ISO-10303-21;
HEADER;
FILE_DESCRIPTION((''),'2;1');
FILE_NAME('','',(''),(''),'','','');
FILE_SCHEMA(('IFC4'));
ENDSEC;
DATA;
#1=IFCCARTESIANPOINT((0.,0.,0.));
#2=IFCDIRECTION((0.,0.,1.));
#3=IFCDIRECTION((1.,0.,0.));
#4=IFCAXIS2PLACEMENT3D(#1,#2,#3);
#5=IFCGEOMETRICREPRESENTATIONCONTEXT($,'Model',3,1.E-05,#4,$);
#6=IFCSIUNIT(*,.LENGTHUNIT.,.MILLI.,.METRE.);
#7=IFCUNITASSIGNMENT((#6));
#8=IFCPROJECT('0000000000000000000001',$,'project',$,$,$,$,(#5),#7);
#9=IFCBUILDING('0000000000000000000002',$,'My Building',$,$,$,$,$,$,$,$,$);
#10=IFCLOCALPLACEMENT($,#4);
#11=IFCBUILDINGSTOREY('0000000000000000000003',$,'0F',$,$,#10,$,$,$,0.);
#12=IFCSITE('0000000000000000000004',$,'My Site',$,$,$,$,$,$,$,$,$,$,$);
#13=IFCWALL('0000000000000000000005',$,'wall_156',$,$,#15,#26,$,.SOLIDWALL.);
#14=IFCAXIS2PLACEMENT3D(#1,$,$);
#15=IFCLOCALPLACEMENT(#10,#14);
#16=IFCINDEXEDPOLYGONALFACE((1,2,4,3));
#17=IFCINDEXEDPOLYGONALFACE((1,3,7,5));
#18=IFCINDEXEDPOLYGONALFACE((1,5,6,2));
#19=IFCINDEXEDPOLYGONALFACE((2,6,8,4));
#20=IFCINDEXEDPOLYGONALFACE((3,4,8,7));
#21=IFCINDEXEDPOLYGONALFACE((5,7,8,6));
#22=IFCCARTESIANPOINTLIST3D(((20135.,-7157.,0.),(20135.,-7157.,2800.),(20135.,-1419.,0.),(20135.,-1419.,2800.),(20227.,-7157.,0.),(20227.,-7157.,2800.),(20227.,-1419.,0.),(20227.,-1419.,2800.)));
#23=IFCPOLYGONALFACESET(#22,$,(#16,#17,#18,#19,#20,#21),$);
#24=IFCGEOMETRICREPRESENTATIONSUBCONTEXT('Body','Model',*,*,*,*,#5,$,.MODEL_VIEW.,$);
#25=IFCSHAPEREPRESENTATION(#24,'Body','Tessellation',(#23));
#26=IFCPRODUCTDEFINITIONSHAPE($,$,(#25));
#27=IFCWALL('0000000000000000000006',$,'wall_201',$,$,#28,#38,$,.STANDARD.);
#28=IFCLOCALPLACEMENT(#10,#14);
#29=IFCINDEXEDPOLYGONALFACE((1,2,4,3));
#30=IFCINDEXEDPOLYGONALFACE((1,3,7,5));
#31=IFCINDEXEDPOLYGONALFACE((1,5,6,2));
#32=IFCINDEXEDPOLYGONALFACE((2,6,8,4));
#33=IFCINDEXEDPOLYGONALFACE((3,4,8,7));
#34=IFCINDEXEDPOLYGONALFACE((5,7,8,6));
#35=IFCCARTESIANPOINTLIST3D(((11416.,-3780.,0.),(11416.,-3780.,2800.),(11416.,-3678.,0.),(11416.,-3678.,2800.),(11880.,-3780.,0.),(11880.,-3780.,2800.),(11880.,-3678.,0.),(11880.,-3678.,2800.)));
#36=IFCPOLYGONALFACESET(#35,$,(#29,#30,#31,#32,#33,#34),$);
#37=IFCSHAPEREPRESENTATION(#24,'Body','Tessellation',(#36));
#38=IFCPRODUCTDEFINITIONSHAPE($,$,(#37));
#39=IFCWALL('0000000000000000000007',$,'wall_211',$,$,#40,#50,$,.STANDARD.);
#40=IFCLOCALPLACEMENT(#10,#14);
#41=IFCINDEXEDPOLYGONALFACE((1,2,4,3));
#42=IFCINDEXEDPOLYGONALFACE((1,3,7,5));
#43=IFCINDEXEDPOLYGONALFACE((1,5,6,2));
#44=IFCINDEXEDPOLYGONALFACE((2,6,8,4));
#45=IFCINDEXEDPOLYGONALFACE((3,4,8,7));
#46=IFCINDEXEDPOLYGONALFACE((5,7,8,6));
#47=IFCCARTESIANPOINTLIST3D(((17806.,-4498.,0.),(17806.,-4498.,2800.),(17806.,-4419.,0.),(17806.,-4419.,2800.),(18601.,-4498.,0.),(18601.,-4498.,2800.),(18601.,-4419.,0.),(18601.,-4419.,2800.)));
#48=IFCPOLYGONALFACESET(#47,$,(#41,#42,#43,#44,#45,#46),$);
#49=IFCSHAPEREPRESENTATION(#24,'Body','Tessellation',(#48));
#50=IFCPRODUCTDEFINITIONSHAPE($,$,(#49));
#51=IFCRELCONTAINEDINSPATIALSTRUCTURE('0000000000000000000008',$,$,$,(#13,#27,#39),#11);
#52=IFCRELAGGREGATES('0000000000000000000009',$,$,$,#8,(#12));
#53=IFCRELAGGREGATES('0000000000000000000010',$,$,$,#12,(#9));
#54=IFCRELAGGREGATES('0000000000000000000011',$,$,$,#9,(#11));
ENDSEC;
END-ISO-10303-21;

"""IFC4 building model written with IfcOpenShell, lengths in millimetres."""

from ifc_helpers import new_model, si_unit, origin_with_axes, place, context, subcontext, project, spatial, indexed_curve, outline, extrude, element, save


model = new_model("IFC4")

# Units and contexts
model_context = context("Model", 3, precision=1e-05, world=origin_with_axes())
body_context = subcontext(model_context, "Body", "Model", "MODEL_VIEW")
ifc_project = project(units=[si_unit("LENGTHUNIT", "METRE", prefix="MILLI")], contexts=[model_context])

# Site, building, storey
site = spatial("IfcSite", under=ifc_project, Name="My Site")
building = spatial("IfcBuilding", under=site, Name="My Building")
storey_placement = place(None, origin_with_axes())
storey = spatial("IfcBuildingStorey", under=building, at=storey_placement, Name="0F", Elevation=0.0)

# Walls
wall_1_placement = place(storey_placement, origin_with_axes())
element("IfcWall", 1, at=wall_1_placement, inside=storey, Name="wall_156", PredefinedType="SOLIDWALL", context=body_context, shape_type="SweptSolid", body=[
    extrude(outline(indexed_curve([(20135.0, -1419.0), (20135.0, -7157.0), (20227.0, -7157.0), (20227.0, -1419.0), (20135.0, -1419.0)])), None, (0.0, 0.0, 1.0), 2800.0),
])
wall_2_placement = place(storey_placement, origin_with_axes())
element("IfcWall", 2, at=wall_2_placement, inside=storey, Name="wall_201", PredefinedType="STANDARD", context=body_context, shape_type="SweptSolid", body=[
    extrude(outline(indexed_curve([(11416.0, -3780.0), (11880.0, -3780.0), (11880.0, -3678.0), (11416.0, -3678.0), (11416.0, -3780.0)])), None, (0.0, 0.0, 1.0), 2800.0),
])
wall_3_placement = place(storey_placement, origin_with_axes())
element("IfcWall", 3, at=wall_3_placement, inside=storey, Name="wall_211", PredefinedType="STANDARD", context=body_context, shape_type="SweptSolid", body=[
    extrude(outline(indexed_curve([(17806.0, -4498.0), (18601.0, -4498.0), (18601.0, -4419.0), (17806.0, -4419.0), (17806.0, -4498.0)])), None, (0.0, 0.0, 1.0), 2800.0),
])

save(model, "model.ifc")
